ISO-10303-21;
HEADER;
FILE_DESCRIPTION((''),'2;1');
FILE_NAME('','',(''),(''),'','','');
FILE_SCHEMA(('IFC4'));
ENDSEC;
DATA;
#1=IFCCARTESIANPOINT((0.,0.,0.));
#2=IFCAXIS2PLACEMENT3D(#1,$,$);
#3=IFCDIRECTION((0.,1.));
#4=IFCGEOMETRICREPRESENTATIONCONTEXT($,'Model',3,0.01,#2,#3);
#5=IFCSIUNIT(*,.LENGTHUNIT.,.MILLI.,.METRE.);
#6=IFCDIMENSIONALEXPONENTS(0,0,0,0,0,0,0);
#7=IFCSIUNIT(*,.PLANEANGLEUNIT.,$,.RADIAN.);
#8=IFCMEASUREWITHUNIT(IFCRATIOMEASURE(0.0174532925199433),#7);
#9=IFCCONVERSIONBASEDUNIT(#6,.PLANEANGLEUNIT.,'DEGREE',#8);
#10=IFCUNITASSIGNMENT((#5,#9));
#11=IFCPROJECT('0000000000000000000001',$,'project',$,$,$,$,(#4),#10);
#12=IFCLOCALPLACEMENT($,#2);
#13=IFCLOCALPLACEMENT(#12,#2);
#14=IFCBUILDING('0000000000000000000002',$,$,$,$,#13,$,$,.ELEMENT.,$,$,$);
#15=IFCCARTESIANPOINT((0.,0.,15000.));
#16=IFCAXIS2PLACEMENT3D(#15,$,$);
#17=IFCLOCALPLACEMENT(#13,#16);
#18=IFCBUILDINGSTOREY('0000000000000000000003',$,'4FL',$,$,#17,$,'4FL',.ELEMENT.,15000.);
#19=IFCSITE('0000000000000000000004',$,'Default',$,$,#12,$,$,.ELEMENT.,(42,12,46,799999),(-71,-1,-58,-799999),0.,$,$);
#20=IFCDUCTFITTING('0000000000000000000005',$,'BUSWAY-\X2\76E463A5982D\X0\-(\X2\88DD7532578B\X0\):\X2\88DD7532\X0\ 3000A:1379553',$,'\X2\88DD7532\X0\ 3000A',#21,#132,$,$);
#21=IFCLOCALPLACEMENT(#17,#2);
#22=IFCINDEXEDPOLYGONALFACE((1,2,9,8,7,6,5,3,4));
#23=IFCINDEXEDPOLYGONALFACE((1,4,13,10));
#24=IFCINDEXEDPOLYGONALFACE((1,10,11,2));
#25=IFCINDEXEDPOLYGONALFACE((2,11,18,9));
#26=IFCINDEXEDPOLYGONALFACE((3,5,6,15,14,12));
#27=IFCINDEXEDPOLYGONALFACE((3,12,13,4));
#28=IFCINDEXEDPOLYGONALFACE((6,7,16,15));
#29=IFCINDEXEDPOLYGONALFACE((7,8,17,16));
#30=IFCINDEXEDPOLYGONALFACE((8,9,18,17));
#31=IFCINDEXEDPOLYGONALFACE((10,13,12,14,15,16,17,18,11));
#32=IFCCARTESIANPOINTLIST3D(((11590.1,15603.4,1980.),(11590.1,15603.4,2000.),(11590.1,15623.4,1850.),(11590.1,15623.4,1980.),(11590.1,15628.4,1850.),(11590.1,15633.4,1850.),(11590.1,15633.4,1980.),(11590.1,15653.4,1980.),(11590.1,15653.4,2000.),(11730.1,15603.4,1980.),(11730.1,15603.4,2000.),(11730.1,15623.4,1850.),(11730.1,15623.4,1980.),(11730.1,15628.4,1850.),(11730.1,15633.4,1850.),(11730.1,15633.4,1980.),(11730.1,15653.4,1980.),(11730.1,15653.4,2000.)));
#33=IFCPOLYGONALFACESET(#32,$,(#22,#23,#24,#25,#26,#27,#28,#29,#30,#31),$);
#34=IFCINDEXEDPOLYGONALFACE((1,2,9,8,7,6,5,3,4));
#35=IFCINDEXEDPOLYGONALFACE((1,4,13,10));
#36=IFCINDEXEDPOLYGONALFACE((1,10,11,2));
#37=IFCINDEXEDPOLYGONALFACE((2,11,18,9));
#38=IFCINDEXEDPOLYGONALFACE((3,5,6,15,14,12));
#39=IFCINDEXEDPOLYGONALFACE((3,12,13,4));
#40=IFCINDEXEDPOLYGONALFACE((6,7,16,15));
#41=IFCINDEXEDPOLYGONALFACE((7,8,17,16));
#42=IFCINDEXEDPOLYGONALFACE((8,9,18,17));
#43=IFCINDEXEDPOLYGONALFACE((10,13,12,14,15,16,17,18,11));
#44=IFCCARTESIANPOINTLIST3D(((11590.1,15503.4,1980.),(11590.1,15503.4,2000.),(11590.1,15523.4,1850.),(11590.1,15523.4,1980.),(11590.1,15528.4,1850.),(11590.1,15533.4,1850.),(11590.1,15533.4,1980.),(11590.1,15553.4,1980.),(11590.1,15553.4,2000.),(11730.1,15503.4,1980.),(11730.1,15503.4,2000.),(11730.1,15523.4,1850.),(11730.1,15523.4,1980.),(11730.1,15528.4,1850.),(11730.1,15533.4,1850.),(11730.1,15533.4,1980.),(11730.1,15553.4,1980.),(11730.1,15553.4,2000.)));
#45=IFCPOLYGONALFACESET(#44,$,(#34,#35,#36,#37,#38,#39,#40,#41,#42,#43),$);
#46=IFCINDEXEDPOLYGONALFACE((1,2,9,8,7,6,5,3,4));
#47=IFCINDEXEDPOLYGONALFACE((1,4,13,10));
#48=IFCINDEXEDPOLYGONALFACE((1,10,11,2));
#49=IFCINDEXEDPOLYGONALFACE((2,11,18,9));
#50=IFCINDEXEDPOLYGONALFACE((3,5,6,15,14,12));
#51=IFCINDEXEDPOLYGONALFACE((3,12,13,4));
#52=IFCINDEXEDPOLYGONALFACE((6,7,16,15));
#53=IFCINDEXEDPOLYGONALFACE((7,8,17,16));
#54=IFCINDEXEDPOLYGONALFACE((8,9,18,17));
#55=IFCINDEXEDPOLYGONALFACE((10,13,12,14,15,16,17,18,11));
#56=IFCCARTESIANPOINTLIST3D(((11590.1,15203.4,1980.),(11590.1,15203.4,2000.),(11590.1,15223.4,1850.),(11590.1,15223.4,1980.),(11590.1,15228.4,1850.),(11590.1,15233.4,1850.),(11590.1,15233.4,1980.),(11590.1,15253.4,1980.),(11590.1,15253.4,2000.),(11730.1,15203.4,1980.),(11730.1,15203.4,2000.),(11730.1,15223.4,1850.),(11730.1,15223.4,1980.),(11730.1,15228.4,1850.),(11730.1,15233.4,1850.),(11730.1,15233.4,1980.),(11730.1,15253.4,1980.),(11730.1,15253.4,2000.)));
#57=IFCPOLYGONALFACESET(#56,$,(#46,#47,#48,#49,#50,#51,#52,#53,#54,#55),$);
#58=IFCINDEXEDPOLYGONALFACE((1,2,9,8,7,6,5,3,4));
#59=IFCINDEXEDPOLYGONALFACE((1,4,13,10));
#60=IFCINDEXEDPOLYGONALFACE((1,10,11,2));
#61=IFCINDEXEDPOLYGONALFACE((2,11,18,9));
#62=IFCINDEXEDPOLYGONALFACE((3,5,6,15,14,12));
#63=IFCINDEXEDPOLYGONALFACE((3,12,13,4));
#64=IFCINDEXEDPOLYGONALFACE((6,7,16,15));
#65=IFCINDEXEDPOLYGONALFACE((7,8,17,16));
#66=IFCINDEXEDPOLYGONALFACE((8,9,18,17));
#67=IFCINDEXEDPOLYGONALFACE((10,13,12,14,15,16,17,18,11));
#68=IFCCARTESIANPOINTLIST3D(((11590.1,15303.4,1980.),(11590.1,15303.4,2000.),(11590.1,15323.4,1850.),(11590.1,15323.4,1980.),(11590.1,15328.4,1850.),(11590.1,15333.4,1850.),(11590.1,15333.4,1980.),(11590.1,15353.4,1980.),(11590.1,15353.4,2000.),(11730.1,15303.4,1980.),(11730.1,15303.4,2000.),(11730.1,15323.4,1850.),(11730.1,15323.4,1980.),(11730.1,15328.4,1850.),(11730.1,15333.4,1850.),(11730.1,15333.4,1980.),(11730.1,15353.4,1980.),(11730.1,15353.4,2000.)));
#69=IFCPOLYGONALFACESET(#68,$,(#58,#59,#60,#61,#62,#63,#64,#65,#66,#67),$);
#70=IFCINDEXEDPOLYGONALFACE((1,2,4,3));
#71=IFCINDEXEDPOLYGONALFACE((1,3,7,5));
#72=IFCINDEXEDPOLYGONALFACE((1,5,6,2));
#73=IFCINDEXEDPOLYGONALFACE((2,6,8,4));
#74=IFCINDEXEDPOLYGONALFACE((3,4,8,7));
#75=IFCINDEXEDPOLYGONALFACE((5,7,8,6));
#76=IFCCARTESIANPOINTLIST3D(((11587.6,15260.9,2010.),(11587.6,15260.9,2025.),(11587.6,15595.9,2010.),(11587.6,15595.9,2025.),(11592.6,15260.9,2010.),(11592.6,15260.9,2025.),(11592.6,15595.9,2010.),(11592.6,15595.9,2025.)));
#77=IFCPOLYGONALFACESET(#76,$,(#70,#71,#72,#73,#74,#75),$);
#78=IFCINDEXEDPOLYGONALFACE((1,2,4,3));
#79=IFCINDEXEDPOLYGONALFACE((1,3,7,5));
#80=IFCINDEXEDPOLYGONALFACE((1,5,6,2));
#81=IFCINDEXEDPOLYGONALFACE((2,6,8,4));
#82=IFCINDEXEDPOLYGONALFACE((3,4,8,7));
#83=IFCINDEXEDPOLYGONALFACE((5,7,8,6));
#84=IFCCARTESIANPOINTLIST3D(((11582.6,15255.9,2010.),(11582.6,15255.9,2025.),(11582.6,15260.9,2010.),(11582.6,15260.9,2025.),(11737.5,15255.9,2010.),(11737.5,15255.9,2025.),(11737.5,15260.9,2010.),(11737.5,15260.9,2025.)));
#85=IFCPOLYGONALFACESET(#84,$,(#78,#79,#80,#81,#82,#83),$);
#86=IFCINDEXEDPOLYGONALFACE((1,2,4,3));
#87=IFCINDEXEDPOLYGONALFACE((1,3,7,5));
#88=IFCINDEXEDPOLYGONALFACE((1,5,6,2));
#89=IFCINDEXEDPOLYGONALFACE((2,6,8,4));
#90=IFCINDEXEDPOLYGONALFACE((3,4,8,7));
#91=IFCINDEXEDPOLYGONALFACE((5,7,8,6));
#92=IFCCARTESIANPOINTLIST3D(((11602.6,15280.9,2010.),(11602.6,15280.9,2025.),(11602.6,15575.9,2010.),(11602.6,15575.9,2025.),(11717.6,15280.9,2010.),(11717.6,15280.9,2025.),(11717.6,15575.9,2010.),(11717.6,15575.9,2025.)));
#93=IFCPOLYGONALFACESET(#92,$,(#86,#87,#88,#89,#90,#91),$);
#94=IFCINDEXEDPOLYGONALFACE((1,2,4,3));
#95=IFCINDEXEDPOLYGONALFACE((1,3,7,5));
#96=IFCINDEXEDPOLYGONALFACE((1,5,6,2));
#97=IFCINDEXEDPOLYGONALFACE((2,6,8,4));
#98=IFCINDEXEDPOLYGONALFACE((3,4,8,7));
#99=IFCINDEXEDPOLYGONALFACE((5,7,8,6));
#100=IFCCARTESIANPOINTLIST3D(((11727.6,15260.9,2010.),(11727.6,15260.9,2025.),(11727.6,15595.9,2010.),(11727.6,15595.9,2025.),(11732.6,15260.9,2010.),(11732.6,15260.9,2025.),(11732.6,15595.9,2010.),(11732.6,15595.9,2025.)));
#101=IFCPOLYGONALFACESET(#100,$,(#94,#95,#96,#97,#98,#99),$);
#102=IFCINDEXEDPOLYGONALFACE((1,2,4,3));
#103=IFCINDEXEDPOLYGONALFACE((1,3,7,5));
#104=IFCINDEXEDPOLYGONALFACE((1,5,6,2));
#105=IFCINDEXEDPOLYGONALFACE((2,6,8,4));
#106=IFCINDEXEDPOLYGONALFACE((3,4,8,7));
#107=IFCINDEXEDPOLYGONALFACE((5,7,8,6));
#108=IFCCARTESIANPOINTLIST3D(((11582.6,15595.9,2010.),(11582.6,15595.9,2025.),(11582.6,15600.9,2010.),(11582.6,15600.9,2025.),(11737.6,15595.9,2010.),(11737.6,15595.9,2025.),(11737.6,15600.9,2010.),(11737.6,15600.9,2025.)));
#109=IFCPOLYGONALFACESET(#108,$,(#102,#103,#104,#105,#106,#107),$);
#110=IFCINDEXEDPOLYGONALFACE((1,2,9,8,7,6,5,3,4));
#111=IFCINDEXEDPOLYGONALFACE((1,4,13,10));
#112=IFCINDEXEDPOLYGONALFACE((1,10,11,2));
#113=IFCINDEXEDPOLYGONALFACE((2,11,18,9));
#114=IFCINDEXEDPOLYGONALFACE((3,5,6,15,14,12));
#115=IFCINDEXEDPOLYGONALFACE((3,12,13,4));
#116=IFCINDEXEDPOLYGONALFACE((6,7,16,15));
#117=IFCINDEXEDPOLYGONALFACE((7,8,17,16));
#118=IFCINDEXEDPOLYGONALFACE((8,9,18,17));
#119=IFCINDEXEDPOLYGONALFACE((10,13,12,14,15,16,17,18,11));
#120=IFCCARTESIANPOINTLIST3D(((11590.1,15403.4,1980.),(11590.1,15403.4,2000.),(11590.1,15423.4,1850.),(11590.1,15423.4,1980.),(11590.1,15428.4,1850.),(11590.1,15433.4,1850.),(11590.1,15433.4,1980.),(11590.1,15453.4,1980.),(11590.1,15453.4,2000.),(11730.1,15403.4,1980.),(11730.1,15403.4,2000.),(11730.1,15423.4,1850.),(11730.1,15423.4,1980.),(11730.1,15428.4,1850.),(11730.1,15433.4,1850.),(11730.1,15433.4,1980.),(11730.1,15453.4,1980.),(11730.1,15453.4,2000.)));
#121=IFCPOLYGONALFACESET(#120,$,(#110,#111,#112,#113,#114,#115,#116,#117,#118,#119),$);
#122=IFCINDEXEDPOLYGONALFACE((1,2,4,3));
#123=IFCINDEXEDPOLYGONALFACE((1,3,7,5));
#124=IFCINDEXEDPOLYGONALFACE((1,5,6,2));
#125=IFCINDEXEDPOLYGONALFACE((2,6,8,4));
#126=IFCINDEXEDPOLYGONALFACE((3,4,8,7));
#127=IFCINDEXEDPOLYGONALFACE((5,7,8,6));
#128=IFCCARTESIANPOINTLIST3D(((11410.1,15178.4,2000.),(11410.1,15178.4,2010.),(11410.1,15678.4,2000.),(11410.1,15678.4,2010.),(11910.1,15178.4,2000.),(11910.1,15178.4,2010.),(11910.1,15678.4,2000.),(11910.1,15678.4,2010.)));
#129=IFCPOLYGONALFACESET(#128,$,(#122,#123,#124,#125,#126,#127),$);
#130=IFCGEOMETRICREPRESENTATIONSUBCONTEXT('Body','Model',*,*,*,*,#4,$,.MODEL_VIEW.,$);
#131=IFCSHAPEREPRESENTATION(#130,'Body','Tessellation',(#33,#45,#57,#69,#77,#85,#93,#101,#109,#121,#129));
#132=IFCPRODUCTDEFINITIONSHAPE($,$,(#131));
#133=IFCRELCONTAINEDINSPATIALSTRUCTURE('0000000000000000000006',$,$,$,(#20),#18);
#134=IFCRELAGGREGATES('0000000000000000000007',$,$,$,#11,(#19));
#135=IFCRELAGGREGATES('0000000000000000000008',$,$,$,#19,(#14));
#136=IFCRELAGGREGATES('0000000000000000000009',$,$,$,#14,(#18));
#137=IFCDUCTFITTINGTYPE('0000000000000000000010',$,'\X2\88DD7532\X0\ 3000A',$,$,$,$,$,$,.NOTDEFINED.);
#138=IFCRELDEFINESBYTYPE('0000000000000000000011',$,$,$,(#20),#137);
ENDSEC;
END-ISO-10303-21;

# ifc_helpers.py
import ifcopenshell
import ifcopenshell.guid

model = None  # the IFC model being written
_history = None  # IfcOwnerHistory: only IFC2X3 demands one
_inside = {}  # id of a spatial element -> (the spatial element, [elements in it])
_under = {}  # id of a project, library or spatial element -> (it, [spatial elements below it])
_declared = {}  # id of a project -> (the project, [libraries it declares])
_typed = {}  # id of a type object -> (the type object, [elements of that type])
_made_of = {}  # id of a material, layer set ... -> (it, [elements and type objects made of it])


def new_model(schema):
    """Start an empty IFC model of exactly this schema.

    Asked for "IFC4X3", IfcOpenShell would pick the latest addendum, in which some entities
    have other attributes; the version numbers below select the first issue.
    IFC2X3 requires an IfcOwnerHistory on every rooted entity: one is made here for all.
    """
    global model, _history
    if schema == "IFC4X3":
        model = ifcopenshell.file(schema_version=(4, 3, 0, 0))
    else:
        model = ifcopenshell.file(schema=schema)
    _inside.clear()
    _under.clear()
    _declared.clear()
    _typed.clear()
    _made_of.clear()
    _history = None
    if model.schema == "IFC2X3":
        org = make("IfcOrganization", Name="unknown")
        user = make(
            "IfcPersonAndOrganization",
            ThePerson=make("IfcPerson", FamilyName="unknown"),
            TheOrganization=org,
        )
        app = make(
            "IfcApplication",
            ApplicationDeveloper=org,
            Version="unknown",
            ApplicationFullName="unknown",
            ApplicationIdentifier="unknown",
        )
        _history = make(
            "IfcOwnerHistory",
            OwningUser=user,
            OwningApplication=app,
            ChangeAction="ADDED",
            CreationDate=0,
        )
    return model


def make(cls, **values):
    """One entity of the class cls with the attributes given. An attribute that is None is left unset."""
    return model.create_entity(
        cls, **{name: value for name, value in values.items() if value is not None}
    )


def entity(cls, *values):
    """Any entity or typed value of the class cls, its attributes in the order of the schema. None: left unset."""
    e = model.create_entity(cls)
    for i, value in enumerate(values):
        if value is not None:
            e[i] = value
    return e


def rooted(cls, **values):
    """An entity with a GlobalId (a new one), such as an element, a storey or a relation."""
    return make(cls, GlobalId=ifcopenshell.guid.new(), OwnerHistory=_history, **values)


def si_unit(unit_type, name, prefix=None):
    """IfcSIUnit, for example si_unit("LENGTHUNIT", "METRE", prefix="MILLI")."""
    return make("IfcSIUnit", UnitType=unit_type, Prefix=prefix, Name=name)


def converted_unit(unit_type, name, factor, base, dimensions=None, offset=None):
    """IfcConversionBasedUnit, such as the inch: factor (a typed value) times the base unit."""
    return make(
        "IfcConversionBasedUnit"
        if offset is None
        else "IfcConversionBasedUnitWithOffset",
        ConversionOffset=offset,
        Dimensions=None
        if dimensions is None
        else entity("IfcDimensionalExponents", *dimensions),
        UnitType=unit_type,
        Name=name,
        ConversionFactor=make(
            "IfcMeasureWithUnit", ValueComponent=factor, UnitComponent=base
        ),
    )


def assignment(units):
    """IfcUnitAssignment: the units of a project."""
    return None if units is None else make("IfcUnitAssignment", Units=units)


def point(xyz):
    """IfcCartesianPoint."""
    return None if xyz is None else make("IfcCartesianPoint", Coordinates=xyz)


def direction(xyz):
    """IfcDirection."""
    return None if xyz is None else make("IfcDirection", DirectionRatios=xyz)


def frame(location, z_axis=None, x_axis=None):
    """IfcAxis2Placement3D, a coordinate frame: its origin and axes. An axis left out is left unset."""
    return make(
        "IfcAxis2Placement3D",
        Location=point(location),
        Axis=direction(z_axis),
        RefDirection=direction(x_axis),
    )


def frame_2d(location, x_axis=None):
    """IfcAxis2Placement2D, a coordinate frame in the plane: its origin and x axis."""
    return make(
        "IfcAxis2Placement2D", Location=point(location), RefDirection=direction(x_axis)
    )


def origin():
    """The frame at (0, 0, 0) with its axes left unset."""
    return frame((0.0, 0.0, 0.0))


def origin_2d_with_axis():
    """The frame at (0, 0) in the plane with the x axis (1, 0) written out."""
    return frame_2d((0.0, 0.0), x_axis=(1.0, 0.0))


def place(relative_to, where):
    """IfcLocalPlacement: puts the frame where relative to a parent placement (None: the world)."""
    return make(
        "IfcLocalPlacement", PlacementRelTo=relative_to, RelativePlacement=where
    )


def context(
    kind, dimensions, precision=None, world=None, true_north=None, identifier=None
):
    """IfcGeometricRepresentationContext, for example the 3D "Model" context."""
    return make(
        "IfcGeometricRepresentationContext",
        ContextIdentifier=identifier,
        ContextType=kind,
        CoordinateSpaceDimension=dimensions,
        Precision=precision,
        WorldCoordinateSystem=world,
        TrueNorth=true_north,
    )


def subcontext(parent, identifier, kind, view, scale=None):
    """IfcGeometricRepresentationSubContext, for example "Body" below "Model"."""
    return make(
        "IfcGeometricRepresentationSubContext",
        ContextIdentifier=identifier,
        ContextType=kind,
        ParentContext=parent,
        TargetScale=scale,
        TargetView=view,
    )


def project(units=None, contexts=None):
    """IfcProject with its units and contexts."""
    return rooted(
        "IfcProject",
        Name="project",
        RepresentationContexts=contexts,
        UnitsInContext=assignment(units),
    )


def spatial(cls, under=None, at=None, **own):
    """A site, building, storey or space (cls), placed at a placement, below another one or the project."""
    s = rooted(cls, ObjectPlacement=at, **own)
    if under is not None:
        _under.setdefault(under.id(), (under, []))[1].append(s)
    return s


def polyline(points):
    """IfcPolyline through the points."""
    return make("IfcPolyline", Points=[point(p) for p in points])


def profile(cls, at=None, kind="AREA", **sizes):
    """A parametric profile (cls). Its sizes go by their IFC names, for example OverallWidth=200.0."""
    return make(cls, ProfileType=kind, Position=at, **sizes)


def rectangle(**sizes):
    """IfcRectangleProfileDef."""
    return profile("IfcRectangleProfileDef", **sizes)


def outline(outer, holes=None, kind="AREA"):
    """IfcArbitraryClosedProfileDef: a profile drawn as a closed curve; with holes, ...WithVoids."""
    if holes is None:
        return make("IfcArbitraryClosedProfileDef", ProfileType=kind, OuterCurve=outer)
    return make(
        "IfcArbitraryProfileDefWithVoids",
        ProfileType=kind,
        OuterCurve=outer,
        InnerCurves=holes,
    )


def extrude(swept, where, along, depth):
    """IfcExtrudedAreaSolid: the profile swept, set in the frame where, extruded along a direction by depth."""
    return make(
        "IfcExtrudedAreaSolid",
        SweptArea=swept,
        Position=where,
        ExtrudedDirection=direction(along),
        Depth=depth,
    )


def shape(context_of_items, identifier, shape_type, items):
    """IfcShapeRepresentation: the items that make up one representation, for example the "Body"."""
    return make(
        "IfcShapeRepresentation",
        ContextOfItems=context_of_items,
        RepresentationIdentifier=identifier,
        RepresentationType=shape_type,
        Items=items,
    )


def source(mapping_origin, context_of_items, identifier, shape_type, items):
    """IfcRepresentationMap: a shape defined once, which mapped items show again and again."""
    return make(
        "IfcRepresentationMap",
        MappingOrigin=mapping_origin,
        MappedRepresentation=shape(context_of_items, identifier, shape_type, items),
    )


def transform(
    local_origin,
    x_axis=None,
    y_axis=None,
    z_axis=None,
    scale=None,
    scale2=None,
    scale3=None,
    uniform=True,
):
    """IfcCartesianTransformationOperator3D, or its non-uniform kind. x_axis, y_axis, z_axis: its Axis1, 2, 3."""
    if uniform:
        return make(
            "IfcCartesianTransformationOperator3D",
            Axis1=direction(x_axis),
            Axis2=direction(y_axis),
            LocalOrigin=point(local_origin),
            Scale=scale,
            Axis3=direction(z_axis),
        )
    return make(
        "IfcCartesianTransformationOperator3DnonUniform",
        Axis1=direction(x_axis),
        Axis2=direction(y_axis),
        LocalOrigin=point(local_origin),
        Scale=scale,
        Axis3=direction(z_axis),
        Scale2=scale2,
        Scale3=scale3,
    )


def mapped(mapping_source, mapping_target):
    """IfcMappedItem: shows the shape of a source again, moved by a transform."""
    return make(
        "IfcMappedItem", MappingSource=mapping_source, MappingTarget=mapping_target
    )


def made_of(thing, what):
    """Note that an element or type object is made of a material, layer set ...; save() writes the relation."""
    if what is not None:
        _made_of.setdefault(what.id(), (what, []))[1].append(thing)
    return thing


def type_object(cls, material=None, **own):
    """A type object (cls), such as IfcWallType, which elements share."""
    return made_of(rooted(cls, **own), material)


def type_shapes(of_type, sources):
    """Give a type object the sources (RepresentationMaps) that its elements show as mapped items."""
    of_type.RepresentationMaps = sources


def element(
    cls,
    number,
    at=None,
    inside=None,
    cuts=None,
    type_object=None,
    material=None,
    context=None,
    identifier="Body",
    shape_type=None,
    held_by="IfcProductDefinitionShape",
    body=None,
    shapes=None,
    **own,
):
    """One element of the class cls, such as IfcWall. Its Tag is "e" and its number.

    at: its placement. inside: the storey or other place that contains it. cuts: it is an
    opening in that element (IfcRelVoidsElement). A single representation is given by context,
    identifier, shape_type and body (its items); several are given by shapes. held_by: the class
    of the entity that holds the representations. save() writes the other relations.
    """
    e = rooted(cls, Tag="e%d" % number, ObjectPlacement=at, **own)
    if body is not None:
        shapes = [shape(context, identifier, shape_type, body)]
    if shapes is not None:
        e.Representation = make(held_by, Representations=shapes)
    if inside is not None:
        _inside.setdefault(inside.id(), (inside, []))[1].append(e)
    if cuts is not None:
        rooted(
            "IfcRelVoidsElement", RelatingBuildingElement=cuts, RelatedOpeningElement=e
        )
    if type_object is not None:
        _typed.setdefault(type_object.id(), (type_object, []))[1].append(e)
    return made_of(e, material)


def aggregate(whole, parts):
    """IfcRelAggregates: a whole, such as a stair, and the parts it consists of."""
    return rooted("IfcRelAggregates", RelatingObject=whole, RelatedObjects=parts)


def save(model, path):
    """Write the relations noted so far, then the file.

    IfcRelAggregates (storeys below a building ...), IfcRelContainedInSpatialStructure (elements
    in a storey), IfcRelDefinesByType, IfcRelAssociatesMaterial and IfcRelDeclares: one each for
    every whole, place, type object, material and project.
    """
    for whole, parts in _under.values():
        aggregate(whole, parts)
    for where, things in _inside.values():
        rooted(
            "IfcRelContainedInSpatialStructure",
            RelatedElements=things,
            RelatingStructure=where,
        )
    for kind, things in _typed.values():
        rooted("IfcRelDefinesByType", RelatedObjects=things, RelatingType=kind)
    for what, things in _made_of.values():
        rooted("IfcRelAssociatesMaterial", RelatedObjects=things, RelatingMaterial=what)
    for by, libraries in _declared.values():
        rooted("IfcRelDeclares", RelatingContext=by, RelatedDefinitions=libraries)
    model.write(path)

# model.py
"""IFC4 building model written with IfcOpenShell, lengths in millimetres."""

from ifc_helpers import new_model, entity, si_unit, converted_unit, direction, frame, frame_2d, origin, origin_2d_with_axis, place, context, subcontext, project, spatial, polyline, rectangle, outline, extrude, source, transform, mapped, type_object, type_shapes, element, save


model = new_model("IFC4")

# Units and contexts
model_context = context("Model", 3, precision=0.01, world=origin(), true_north=direction((0.0, 1.0)))
body_context = subcontext(model_context, "Body", "Model", "MODEL_VIEW")
ifc_project = project(units=[si_unit("LENGTHUNIT", "METRE", prefix="MILLI"), converted_unit("PLANEANGLEUNIT", "DEGREE", entity("IfcRatioMeasure", 0.0174532925199433), si_unit("PLANEANGLEUNIT", "RADIAN"), dimensions=[0, 0, 0, 0, 0, 0, 0])], contexts=[model_context])

# Site, building, storey
site_placement = place(None, origin())
site = spatial("IfcSite", under=ifc_project, at=site_placement, Name="Default", CompositionType="ELEMENT", RefLatitude=(42, 12, 46, 799999), RefLongitude=(-71, -1, -58, -799999), RefElevation=0.0)
building_placement = place(site_placement, origin())
building = spatial("IfcBuilding", under=site, at=building_placement, CompositionType="ELEMENT")
storey_placement = place(building_placement, frame((0.0, 0.0, 15000.0)))
storey = spatial("IfcBuildingStorey", under=building, at=storey_placement, Name="4FL", LongName="4FL", CompositionType="ELEMENT", Elevation=15000.0)

# Duct fitting
duct_fitting_type_1 = type_object("IfcDuctFittingType", Name="裝甲 3000A", PredefinedType="NOTDEFINED")
shared_shape_1 = source(origin(), body_context, "Body", "SweptSolid", [
    extrude(outline(polyline([(-25.0, -58.9), (25.0, -58.9), (25.0, -38.9), (5.0, -38.9), (5.0, 91.1), (0.0, 91.1), (-5.0, 91.1), (-5.0, -38.9), (-25.0, -38.9), (-25.0, -58.9)])), frame((-200.0, -70.0, -58.9), z_axis=(0.0, 1.0, 0.0), x_axis=(1.0, 0.0, 0.0)), (0.0, 0.0, 1.0), 140.0),
    extrude(outline(polyline([(-25.0, -58.9), (25.0, -58.9), (25.0, -38.9), (5.0, -38.9), (5.0, 91.1), (0.0, 91.1), (-5.0, 91.1), (-5.0, -38.9), (-25.0, -38.9), (-25.0, -58.9)])), frame((-100.0, -70.0, -58.9), z_axis=(0.0, 1.0, 0.0), x_axis=(1.0, 0.0, 0.0)), (0.0, 0.0, 1.0), 140.0),
    extrude(outline(polyline([(-58.9, -25.0), (-38.9, -25.0), (-38.9, -5.0), (91.1, -5.0), (91.1, 0.0), (91.1, 5.0), (-38.9, 5.0), (-38.9, 25.0), (-58.9, 25.0), (-58.9, -25.0)])), frame((200.0, -70.0, -58.9), z_axis=(0.0, 1.0, 0.0), x_axis=(0.0, 0.0, -1.0)), (0.0, 0.0, 1.0), 140.0),
    extrude(outline(polyline([(-58.9, -25.0), (-38.9, -25.0), (-38.9, -5.0), (91.1, -5.0), (91.1, 0.0), (91.1, 5.0), (-38.9, 5.0), (-38.9, 25.0), (-58.9, 25.0), (-58.9, -25.0)])), frame((100.0, -70.0, -58.9), z_axis=(0.0, 1.0, 0.0), x_axis=(0.0, 0.0, -1.0)), (0.0, 0.0, 1.0), 140.0),
    extrude(rectangle(XDim=335.0, YDim=5.0, at=origin_2d_with_axis()), frame((0.0, -70.0, 10.0), z_axis=(0.0, 0.0, 1.0), x_axis=(-1.0, 0.0, 0.0)), (0.0, 0.0, 1.0), 15.0),
    extrude(rectangle(XDim=5.0, YDim=154.9, at=frame_2d((0.0, 0.0), x_axis=(1.0, 0.0))), frame((170.0, -0.1, 10.0), z_axis=(0.0, 0.0, 1.0), x_axis=(-1.0, 0.0, 0.0)), (0.0, 0.0, 1.0), 15.0),
    extrude(rectangle(XDim=295.0, YDim=115.0, at=origin_2d_with_axis()), frame((0.0, 0.0, 10.0), z_axis=(0.0, 0.0, 1.0), x_axis=(-1.0, 0.0, 0.0)), (0.0, 0.0, 1.0), 15.0),
    extrude(rectangle(XDim=335.0, YDim=5.0, at=origin_2d_with_axis()), frame((0.0, 70.0, 10.0), z_axis=(0.0, 0.0, 1.0), x_axis=(-1.0, 0.0, 0.0)), (0.0, 0.0, 1.0), 15.0),
    extrude(rectangle(XDim=5.0, YDim=155.0, at=origin_2d_with_axis()), frame((-170.0, 0.0, 10.0), z_axis=(0.0, 0.0, 1.0), x_axis=(-1.0, 0.0, 0.0)), (0.0, 0.0, 1.0), 15.0),
    extrude(outline(polyline([(-58.9, -25.0), (-38.9, -25.0), (-38.9, -5.0), (91.1, -5.0), (91.1, 0.0), (91.1, 5.0), (-38.9, 5.0), (-38.9, 25.0), (-58.9, 25.0), (-58.9, -25.0)])), frame((0.0, -70.0, -58.9), z_axis=(0.0, 1.0, 0.0), x_axis=(0.0, 0.0, -1.0)), (0.0, 0.0, 1.0), 140.0),
    extrude(rectangle(XDim=500.0, YDim=500.0, at=origin_2d_with_axis()), frame((0.0, 0.0, 0.0), z_axis=(0.0, 0.0, 1.0), x_axis=(0.0, 1.0, 0.0)), (0.0, 0.0, 1.0), 10.0),
])
type_shapes(duct_fitting_type_1, [shared_shape_1])
for number, where, z_axis, x_axis, name in (
    (1, (11660.1, 15428.4, 2000.0), (0.0, 0.0, 1.0), (0.0, -1.0, 0.0), "BUSWAY-盤接頭-(裝甲型):裝甲 3000A:1379553"),
):
    element("IfcDuctFitting", number, at=place(storey_placement, frame(where, z_axis=z_axis, x_axis=x_axis)), inside=storey, type_object=duct_fitting_type_1, Name=name, ObjectType="裝甲 3000A", context=body_context, shape_type="MappedRepresentation", body=[
        mapped(shared_shape_1, transform((0.0, 0.0, 0.0), scale=1.0)),
    ])

save(model, "model.ifc")
